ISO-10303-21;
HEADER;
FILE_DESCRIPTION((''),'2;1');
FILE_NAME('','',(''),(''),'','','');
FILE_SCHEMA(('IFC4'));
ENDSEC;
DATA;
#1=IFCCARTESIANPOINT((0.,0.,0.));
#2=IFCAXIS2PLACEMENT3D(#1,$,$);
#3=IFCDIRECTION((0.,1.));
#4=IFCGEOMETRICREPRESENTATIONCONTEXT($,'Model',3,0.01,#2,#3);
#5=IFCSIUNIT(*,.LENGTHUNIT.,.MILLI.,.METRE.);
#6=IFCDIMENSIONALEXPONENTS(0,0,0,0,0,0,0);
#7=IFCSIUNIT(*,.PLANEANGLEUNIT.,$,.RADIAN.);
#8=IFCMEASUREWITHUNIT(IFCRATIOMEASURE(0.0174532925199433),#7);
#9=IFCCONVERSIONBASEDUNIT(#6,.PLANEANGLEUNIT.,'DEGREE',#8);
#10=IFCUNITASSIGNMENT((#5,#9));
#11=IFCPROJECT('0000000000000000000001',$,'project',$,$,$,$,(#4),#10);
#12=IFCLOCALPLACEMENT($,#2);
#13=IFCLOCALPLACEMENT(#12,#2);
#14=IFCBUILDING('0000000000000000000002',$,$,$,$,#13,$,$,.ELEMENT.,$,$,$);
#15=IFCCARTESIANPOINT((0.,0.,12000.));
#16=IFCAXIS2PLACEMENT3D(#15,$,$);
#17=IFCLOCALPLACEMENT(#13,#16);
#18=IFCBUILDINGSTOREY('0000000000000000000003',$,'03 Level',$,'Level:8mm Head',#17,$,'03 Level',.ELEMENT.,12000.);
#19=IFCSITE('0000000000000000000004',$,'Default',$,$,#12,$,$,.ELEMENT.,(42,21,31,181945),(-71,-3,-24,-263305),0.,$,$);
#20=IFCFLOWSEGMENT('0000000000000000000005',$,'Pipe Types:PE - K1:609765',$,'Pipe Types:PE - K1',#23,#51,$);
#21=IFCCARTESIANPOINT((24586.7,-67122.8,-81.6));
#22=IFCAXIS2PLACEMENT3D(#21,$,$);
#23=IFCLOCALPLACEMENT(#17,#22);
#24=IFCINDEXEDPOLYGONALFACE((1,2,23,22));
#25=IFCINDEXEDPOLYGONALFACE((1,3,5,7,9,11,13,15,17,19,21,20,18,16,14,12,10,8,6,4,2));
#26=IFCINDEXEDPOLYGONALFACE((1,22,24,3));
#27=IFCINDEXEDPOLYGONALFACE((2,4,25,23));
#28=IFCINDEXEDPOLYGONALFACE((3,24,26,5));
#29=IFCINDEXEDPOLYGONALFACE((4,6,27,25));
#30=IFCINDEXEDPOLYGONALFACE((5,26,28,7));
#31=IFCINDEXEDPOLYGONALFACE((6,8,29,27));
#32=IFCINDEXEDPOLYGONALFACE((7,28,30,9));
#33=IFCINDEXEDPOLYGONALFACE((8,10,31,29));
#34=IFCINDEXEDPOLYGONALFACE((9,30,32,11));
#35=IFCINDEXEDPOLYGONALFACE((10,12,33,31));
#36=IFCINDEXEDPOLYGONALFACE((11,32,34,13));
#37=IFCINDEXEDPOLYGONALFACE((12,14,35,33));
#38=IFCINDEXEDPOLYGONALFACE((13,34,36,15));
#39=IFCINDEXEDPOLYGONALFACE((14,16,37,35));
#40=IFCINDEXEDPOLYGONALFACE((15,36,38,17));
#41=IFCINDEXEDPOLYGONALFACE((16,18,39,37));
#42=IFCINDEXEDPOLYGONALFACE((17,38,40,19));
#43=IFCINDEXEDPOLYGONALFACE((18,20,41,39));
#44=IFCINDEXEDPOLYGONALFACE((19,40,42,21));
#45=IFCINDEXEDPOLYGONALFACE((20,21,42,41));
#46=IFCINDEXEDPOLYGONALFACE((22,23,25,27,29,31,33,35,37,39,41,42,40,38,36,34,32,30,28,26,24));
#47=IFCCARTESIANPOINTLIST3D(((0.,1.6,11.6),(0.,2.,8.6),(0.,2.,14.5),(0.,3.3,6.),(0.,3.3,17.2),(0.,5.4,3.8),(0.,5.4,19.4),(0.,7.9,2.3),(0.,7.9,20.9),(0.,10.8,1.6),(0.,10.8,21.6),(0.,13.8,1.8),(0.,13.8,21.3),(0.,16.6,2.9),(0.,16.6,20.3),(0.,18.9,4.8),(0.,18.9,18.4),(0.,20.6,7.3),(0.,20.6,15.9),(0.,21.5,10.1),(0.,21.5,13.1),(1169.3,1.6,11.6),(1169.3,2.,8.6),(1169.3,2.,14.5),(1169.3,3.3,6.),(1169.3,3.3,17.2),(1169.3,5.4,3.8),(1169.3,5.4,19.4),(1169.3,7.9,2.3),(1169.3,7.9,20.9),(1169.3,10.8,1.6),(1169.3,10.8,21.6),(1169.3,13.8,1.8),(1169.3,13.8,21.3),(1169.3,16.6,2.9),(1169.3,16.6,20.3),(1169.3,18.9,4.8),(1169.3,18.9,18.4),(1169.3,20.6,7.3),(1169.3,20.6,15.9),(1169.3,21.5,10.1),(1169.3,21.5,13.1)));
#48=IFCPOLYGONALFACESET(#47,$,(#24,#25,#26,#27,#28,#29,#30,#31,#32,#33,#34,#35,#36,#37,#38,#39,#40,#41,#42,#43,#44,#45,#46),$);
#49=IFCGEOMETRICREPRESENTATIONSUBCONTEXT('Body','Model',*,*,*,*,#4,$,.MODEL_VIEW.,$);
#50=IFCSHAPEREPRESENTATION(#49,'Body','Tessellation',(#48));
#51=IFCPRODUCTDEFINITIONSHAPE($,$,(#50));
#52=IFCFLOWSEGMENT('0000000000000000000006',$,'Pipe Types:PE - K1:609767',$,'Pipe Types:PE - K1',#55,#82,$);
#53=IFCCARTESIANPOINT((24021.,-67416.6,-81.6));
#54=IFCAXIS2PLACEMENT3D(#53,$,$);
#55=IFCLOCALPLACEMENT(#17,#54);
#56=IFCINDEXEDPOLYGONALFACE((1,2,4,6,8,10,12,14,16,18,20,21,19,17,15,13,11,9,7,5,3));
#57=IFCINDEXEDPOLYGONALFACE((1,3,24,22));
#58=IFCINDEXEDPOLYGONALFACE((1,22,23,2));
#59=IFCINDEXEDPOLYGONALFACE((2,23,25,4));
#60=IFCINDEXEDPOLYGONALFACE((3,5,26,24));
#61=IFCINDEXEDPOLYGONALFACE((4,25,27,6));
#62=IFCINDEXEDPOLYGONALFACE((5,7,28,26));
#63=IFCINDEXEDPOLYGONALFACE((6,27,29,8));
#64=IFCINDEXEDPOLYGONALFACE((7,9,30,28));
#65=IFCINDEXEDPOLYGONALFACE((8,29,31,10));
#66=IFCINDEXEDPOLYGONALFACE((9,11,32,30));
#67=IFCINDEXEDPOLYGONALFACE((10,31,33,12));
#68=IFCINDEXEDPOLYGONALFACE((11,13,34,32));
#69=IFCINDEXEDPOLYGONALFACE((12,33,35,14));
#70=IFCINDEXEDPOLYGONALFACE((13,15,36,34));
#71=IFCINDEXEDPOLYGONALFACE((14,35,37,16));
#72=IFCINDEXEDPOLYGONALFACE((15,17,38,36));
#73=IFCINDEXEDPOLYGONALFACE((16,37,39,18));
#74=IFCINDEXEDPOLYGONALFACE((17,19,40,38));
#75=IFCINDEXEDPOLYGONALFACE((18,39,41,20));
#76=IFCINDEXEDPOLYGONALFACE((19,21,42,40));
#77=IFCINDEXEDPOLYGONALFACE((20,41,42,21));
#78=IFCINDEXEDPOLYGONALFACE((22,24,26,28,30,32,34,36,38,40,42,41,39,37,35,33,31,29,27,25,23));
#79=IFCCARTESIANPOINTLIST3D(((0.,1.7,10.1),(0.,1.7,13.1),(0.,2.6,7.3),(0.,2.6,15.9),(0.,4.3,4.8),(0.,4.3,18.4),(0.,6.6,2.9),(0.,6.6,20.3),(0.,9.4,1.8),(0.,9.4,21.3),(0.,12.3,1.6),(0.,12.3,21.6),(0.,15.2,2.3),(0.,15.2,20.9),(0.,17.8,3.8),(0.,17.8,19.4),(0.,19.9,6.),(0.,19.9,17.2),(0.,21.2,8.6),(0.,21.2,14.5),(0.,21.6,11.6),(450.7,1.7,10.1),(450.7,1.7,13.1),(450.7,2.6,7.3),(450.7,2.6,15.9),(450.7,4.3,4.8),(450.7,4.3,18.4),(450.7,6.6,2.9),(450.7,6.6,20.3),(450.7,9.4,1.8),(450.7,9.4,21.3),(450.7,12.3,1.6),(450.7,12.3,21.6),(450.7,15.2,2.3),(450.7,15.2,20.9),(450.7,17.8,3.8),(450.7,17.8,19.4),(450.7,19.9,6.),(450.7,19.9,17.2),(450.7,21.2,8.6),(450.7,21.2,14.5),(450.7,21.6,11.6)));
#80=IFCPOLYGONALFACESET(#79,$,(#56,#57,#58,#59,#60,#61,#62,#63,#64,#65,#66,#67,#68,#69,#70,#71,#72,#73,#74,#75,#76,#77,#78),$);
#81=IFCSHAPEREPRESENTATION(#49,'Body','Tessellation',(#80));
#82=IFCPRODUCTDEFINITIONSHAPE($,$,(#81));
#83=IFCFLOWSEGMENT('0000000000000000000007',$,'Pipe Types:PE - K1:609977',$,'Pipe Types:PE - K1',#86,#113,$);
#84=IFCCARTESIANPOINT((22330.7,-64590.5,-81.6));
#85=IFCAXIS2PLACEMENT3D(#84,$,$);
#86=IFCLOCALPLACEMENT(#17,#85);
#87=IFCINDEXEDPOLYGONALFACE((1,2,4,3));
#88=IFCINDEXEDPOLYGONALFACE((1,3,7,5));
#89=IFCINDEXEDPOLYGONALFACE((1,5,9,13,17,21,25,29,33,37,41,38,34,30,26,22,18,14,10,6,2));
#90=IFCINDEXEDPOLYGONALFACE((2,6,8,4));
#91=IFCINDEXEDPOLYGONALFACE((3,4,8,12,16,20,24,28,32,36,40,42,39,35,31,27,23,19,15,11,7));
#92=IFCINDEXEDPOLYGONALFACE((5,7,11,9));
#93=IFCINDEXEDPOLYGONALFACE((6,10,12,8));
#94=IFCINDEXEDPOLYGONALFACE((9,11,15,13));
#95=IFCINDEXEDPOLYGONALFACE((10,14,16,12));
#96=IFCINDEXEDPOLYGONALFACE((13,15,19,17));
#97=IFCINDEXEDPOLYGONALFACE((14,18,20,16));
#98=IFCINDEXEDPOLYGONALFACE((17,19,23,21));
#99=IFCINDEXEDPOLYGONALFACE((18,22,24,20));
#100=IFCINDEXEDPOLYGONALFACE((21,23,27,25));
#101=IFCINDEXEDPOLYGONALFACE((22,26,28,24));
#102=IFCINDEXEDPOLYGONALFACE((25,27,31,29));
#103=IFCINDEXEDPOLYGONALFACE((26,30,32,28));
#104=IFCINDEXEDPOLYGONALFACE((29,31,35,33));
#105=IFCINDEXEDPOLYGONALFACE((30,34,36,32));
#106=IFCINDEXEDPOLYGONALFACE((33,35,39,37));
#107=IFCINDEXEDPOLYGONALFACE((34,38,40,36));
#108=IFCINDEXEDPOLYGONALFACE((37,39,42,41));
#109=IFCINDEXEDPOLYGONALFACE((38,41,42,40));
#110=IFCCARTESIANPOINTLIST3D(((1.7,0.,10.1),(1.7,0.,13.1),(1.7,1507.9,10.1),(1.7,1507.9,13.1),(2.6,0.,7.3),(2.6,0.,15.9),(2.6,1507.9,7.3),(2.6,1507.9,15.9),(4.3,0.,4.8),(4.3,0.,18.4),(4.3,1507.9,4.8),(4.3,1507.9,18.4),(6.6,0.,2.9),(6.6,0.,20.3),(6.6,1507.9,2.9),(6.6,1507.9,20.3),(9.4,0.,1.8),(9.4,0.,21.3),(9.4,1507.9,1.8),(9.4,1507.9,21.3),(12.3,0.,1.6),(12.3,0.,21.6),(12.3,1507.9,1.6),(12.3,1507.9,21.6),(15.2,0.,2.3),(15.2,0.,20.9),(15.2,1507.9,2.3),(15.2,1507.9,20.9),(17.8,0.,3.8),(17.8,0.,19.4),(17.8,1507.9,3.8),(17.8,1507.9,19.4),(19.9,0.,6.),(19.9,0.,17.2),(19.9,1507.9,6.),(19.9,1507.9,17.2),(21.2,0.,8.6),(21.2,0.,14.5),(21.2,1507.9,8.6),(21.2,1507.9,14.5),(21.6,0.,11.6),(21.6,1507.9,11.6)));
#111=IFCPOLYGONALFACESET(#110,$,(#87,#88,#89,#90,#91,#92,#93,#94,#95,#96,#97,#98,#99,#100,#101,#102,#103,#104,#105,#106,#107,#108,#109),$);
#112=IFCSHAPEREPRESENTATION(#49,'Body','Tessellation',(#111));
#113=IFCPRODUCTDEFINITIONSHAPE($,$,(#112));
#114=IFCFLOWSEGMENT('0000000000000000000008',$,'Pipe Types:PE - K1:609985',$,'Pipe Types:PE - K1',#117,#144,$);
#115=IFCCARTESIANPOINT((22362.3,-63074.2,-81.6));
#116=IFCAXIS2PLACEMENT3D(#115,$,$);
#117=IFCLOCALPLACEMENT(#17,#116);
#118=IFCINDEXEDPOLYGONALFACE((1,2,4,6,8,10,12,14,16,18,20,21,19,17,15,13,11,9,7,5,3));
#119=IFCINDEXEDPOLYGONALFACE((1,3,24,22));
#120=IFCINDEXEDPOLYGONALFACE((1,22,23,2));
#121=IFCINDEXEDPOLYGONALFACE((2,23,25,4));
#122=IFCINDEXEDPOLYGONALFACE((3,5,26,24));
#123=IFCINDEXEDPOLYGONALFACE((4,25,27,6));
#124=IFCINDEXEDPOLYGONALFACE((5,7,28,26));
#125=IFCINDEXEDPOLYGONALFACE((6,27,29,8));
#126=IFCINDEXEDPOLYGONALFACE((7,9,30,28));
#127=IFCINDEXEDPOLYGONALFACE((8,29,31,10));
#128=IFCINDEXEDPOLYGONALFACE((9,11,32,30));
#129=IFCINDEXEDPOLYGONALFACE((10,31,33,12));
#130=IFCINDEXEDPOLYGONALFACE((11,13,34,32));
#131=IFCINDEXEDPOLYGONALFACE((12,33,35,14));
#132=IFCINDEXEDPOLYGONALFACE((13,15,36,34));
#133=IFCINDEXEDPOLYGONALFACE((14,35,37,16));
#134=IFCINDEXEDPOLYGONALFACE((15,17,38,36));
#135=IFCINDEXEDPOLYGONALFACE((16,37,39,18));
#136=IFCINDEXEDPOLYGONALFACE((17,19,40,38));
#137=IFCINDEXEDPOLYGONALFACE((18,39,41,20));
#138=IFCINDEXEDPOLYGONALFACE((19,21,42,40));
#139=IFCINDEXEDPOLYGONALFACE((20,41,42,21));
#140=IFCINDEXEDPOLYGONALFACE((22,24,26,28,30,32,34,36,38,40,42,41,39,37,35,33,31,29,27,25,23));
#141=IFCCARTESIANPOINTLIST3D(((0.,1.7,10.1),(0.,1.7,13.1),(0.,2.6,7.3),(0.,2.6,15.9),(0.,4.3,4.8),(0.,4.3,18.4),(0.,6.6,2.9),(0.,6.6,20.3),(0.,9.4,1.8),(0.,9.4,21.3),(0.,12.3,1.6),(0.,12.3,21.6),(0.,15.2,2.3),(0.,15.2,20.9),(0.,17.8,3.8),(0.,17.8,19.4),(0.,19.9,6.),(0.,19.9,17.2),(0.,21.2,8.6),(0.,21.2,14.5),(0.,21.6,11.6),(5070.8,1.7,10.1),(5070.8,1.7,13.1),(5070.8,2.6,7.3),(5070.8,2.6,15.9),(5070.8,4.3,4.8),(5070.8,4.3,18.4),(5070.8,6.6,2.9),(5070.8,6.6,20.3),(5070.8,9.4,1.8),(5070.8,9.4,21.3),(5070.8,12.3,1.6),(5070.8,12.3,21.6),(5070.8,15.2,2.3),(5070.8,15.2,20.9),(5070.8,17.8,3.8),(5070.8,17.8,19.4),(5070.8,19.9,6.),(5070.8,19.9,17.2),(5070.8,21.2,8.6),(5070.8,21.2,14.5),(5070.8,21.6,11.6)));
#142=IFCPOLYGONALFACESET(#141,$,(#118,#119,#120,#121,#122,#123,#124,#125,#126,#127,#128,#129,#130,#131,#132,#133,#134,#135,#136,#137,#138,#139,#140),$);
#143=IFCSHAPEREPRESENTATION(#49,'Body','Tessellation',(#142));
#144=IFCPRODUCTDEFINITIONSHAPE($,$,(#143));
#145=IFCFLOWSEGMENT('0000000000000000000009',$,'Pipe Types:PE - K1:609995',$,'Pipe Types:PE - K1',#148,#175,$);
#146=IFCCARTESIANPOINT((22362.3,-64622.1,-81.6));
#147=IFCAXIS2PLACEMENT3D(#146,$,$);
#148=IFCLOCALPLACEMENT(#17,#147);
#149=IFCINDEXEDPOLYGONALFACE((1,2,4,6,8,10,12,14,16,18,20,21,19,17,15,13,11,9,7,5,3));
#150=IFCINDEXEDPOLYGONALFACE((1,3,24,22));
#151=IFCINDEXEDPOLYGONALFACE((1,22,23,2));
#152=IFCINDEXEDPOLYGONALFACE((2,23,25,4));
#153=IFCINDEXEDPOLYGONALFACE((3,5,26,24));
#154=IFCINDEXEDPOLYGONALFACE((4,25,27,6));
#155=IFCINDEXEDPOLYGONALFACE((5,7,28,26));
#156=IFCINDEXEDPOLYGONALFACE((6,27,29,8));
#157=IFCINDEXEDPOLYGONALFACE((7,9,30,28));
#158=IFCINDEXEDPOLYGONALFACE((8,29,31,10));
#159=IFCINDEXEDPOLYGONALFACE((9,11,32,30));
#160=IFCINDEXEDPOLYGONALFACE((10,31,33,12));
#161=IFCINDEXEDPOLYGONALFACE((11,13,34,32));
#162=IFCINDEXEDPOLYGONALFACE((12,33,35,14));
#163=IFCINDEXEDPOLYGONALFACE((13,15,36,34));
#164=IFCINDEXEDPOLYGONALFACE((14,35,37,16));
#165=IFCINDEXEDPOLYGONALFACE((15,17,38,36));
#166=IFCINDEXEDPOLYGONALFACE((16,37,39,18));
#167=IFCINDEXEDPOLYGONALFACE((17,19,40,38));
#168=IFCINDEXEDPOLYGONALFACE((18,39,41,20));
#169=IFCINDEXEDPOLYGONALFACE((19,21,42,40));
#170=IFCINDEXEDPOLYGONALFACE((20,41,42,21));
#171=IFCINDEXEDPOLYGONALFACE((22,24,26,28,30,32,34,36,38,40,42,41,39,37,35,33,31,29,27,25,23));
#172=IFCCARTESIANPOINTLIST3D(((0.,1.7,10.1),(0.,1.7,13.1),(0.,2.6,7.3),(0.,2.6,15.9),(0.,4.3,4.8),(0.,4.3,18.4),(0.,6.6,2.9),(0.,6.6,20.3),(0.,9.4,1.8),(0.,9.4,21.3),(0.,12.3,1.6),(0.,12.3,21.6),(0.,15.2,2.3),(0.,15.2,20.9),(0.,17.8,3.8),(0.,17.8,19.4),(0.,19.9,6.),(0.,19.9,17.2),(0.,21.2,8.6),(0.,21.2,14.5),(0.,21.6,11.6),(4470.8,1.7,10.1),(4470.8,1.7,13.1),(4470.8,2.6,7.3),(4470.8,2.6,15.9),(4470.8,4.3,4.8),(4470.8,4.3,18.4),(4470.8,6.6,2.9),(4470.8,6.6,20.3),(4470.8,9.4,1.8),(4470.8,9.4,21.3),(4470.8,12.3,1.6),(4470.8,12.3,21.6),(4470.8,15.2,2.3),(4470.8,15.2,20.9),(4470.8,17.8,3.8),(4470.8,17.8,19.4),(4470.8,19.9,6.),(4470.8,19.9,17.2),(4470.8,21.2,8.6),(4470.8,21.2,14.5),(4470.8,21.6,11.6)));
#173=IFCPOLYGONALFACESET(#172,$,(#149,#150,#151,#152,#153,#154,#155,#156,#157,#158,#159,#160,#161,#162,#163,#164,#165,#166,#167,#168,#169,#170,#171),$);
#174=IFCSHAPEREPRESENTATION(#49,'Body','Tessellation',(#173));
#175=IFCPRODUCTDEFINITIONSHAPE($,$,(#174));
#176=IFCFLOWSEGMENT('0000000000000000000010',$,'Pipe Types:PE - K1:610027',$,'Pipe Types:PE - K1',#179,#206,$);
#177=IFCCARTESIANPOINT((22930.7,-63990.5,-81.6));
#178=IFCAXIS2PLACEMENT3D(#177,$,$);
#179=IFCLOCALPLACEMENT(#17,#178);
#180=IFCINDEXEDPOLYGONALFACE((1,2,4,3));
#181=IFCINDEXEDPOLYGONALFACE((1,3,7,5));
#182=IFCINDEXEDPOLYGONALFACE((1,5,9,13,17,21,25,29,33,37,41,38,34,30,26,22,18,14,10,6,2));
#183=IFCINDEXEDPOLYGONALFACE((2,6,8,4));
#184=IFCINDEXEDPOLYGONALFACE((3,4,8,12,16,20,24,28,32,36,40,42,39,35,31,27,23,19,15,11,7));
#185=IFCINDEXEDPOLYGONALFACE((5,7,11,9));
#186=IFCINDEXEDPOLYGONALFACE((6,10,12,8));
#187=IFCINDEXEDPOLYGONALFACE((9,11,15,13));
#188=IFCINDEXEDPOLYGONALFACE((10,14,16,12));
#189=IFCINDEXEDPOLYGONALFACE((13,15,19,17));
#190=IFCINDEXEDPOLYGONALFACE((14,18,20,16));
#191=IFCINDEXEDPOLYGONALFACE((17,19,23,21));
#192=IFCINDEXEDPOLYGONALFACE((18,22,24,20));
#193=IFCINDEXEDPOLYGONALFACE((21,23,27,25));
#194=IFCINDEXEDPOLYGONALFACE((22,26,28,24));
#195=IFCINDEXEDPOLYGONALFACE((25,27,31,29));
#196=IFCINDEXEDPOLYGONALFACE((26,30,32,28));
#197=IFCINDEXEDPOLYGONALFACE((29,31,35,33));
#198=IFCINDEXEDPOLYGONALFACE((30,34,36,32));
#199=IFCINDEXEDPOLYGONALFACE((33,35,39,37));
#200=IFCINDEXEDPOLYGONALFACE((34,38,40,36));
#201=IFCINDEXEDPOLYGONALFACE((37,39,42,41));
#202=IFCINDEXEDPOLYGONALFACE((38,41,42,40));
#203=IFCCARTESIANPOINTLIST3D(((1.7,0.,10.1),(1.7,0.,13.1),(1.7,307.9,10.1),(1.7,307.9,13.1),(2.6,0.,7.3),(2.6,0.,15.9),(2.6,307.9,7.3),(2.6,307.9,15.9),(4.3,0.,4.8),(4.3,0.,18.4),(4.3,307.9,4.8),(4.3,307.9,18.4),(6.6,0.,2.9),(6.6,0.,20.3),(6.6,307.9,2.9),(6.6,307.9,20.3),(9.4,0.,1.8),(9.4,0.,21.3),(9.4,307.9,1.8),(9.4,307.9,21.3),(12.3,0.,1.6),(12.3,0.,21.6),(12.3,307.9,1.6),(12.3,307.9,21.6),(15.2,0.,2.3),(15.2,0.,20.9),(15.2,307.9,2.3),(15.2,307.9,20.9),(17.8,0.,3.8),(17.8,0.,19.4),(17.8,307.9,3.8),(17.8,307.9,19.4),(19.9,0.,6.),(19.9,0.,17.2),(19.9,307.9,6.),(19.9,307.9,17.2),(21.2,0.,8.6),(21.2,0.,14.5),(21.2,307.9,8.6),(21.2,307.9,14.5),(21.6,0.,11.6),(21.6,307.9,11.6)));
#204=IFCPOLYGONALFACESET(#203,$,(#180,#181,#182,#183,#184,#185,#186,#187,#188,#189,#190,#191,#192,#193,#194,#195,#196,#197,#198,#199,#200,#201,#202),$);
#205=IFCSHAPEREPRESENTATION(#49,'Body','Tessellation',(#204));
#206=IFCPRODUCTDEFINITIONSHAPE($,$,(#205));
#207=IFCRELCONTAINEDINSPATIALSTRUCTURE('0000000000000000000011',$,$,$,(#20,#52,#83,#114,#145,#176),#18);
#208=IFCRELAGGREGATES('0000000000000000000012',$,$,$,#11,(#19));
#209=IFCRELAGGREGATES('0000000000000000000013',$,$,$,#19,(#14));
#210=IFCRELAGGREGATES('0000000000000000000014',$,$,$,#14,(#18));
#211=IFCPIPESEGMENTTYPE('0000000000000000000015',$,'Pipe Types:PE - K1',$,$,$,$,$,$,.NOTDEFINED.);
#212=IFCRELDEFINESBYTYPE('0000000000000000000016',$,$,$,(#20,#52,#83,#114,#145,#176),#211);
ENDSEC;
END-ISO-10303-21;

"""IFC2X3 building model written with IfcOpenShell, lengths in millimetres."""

from ifc_helpers import new_model, entity, si_unit, converted_unit, direction, frame, frame_2d, origin, origin_2d_with_axis, place, context, subcontext, project, spatial, circle, extrude, type_object, element, save


model = new_model("IFC2X3")

# Units and contexts
model_context = context("Model", 3, precision=0.01, world=origin(), true_north=direction((0.0, 1.0)))
body_context = subcontext(model_context, "Body", "Model", "MODEL_VIEW")
ifc_project = project(units=[si_unit("LENGTHUNIT", "METRE", prefix="MILLI"), converted_unit("PLANEANGLEUNIT", "DEGREE", entity("IfcRatioMeasure", 0.0174532925199433), si_unit("PLANEANGLEUNIT", "RADIAN"), dimensions=[0, 0, 0, 0, 0, 0, 0])], contexts=[model_context])

# Site, building, storey
site_placement = place(None, origin())
site = spatial("IfcSite", under=ifc_project, at=site_placement, Name="Default", CompositionType="ELEMENT", RefLatitude=(42, 21, 31, 181945), RefLongitude=(-71, -3, -24, -263305), RefElevation=0.0)
building_placement = place(site_placement, origin())
building = spatial("IfcBuilding", under=site, at=building_placement, CompositionType="ELEMENT")
storey_placement = place(building_placement, frame((0.0, 0.0, 12000.0)))
storey = spatial("IfcBuildingStorey", under=building, at=storey_placement, Name="03 Level", ObjectType="Level:8mm Head", LongName="03 Level", CompositionType="ELEMENT", Elevation=12000.0)

# Flow segments
pipe_segment_type = type_object("IfcPipeSegmentType", Name="Pipe Types:PE - K1", PredefinedType="NOTDEFINED")
flow_segment_1_placement = place(storey_placement, frame((24586.7, -67122.8, -81.6)))
element("IfcFlowSegment", 1, at=flow_segment_1_placement, inside=storey, type_object=pipe_segment_type, Name="Pipe Types:PE - K1:609765", ObjectType="Pipe Types:PE - K1", context=body_context, shape_type="SweptSolid", body=[
    extrude(circle(Radius=10.0, at=origin_2d_with_axis()), frame((0.0, 11.6, 11.6), z_axis=(1.0, 0.0, 0.0), x_axis=(0.0, -1.0, 0.0)), (0.0, 0.0, 1.0), 1169.3),
])
flow_segment_2_placement = place(storey_placement, frame((24021.0, -67416.6, -81.6)))
element("IfcFlowSegment", 2, at=flow_segment_2_placement, inside=storey, type_object=pipe_segment_type, Name="Pipe Types:PE - K1:609767", ObjectType="Pipe Types:PE - K1", context=body_context, shape_type="SweptSolid", body=[
    extrude(circle(Radius=10.0, at=frame_2d((0.0, 0.0), x_axis=(1.0, 0.0))), frame((0.0, 11.6, 11.6), z_axis=(1.0, 0.0, 0.0), x_axis=(0.0, 1.0, 0.0)), (0.0, 0.0, 1.0), 450.7),
])
flow_segment_3_placement = place(storey_placement, frame((22330.7, -64590.5, -81.6)))
element("IfcFlowSegment", 3, at=flow_segment_3_placement, inside=storey, type_object=pipe_segment_type, Name="Pipe Types:PE - K1:609977", ObjectType="Pipe Types:PE - K1", context=body_context, shape_type="SweptSolid", body=[
    extrude(circle(Radius=10.0, at=origin_2d_with_axis()), frame((11.6, 0.0, 11.6), z_axis=(0.0, 1.0, 0.0), x_axis=(1.0, 0.0, 0.0)), (0.0, 0.0, 1.0), 1507.9),
])
flow_segment_4_placement = place(storey_placement, frame((22362.3, -63074.2, -81.6)))
element("IfcFlowSegment", 4, at=flow_segment_4_placement, inside=storey, type_object=pipe_segment_type, Name="Pipe Types:PE - K1:609985", ObjectType="Pipe Types:PE - K1", context=body_context, shape_type="SweptSolid", body=[
    extrude(circle(Radius=10.0, at=frame_2d((0.0, 0.0), x_axis=(1.0, 0.0))), frame((0.0, 11.6, 11.6), z_axis=(1.0, 0.0, 0.0), x_axis=(0.0, 1.0, 0.0)), (0.0, 0.0, 1.0), 5070.8),
])
flow_segment_5_placement = place(storey_placement, frame((22362.3, -64622.1, -81.6)))
element("IfcFlowSegment", 5, at=flow_segment_5_placement, inside=storey, type_object=pipe_segment_type, Name="Pipe Types:PE - K1:609995", ObjectType="Pipe Types:PE - K1", context=body_context, shape_type="SweptSolid", body=[
    extrude(circle(Radius=10.0, at=frame_2d((0.0, 0.0), x_axis=(1.0, 0.0))), frame((0.0, 11.6, 11.6), z_axis=(1.0, 0.0, 0.0), x_axis=(0.0, 1.0, 0.0)), (0.0, 0.0, 1.0), 4470.8),
])
flow_segment_6_placement = place(storey_placement, frame((22930.7, -63990.5, -81.6)))
element("IfcFlowSegment", 6, at=flow_segment_6_placement, inside=storey, type_object=pipe_segment_type, Name="Pipe Types:PE - K1:610027", ObjectType="Pipe Types:PE - K1", context=body_context, shape_type="SweptSolid", body=[
    extrude(circle(Radius=10.0, at=origin_2d_with_axis()), frame((11.6, 0.0, 11.6), z_axis=(0.0, 1.0, 0.0), x_axis=(1.0, 0.0, 0.0)), (0.0, 0.0, 1.0), 307.9),
])

save(model, "model.ifc")
